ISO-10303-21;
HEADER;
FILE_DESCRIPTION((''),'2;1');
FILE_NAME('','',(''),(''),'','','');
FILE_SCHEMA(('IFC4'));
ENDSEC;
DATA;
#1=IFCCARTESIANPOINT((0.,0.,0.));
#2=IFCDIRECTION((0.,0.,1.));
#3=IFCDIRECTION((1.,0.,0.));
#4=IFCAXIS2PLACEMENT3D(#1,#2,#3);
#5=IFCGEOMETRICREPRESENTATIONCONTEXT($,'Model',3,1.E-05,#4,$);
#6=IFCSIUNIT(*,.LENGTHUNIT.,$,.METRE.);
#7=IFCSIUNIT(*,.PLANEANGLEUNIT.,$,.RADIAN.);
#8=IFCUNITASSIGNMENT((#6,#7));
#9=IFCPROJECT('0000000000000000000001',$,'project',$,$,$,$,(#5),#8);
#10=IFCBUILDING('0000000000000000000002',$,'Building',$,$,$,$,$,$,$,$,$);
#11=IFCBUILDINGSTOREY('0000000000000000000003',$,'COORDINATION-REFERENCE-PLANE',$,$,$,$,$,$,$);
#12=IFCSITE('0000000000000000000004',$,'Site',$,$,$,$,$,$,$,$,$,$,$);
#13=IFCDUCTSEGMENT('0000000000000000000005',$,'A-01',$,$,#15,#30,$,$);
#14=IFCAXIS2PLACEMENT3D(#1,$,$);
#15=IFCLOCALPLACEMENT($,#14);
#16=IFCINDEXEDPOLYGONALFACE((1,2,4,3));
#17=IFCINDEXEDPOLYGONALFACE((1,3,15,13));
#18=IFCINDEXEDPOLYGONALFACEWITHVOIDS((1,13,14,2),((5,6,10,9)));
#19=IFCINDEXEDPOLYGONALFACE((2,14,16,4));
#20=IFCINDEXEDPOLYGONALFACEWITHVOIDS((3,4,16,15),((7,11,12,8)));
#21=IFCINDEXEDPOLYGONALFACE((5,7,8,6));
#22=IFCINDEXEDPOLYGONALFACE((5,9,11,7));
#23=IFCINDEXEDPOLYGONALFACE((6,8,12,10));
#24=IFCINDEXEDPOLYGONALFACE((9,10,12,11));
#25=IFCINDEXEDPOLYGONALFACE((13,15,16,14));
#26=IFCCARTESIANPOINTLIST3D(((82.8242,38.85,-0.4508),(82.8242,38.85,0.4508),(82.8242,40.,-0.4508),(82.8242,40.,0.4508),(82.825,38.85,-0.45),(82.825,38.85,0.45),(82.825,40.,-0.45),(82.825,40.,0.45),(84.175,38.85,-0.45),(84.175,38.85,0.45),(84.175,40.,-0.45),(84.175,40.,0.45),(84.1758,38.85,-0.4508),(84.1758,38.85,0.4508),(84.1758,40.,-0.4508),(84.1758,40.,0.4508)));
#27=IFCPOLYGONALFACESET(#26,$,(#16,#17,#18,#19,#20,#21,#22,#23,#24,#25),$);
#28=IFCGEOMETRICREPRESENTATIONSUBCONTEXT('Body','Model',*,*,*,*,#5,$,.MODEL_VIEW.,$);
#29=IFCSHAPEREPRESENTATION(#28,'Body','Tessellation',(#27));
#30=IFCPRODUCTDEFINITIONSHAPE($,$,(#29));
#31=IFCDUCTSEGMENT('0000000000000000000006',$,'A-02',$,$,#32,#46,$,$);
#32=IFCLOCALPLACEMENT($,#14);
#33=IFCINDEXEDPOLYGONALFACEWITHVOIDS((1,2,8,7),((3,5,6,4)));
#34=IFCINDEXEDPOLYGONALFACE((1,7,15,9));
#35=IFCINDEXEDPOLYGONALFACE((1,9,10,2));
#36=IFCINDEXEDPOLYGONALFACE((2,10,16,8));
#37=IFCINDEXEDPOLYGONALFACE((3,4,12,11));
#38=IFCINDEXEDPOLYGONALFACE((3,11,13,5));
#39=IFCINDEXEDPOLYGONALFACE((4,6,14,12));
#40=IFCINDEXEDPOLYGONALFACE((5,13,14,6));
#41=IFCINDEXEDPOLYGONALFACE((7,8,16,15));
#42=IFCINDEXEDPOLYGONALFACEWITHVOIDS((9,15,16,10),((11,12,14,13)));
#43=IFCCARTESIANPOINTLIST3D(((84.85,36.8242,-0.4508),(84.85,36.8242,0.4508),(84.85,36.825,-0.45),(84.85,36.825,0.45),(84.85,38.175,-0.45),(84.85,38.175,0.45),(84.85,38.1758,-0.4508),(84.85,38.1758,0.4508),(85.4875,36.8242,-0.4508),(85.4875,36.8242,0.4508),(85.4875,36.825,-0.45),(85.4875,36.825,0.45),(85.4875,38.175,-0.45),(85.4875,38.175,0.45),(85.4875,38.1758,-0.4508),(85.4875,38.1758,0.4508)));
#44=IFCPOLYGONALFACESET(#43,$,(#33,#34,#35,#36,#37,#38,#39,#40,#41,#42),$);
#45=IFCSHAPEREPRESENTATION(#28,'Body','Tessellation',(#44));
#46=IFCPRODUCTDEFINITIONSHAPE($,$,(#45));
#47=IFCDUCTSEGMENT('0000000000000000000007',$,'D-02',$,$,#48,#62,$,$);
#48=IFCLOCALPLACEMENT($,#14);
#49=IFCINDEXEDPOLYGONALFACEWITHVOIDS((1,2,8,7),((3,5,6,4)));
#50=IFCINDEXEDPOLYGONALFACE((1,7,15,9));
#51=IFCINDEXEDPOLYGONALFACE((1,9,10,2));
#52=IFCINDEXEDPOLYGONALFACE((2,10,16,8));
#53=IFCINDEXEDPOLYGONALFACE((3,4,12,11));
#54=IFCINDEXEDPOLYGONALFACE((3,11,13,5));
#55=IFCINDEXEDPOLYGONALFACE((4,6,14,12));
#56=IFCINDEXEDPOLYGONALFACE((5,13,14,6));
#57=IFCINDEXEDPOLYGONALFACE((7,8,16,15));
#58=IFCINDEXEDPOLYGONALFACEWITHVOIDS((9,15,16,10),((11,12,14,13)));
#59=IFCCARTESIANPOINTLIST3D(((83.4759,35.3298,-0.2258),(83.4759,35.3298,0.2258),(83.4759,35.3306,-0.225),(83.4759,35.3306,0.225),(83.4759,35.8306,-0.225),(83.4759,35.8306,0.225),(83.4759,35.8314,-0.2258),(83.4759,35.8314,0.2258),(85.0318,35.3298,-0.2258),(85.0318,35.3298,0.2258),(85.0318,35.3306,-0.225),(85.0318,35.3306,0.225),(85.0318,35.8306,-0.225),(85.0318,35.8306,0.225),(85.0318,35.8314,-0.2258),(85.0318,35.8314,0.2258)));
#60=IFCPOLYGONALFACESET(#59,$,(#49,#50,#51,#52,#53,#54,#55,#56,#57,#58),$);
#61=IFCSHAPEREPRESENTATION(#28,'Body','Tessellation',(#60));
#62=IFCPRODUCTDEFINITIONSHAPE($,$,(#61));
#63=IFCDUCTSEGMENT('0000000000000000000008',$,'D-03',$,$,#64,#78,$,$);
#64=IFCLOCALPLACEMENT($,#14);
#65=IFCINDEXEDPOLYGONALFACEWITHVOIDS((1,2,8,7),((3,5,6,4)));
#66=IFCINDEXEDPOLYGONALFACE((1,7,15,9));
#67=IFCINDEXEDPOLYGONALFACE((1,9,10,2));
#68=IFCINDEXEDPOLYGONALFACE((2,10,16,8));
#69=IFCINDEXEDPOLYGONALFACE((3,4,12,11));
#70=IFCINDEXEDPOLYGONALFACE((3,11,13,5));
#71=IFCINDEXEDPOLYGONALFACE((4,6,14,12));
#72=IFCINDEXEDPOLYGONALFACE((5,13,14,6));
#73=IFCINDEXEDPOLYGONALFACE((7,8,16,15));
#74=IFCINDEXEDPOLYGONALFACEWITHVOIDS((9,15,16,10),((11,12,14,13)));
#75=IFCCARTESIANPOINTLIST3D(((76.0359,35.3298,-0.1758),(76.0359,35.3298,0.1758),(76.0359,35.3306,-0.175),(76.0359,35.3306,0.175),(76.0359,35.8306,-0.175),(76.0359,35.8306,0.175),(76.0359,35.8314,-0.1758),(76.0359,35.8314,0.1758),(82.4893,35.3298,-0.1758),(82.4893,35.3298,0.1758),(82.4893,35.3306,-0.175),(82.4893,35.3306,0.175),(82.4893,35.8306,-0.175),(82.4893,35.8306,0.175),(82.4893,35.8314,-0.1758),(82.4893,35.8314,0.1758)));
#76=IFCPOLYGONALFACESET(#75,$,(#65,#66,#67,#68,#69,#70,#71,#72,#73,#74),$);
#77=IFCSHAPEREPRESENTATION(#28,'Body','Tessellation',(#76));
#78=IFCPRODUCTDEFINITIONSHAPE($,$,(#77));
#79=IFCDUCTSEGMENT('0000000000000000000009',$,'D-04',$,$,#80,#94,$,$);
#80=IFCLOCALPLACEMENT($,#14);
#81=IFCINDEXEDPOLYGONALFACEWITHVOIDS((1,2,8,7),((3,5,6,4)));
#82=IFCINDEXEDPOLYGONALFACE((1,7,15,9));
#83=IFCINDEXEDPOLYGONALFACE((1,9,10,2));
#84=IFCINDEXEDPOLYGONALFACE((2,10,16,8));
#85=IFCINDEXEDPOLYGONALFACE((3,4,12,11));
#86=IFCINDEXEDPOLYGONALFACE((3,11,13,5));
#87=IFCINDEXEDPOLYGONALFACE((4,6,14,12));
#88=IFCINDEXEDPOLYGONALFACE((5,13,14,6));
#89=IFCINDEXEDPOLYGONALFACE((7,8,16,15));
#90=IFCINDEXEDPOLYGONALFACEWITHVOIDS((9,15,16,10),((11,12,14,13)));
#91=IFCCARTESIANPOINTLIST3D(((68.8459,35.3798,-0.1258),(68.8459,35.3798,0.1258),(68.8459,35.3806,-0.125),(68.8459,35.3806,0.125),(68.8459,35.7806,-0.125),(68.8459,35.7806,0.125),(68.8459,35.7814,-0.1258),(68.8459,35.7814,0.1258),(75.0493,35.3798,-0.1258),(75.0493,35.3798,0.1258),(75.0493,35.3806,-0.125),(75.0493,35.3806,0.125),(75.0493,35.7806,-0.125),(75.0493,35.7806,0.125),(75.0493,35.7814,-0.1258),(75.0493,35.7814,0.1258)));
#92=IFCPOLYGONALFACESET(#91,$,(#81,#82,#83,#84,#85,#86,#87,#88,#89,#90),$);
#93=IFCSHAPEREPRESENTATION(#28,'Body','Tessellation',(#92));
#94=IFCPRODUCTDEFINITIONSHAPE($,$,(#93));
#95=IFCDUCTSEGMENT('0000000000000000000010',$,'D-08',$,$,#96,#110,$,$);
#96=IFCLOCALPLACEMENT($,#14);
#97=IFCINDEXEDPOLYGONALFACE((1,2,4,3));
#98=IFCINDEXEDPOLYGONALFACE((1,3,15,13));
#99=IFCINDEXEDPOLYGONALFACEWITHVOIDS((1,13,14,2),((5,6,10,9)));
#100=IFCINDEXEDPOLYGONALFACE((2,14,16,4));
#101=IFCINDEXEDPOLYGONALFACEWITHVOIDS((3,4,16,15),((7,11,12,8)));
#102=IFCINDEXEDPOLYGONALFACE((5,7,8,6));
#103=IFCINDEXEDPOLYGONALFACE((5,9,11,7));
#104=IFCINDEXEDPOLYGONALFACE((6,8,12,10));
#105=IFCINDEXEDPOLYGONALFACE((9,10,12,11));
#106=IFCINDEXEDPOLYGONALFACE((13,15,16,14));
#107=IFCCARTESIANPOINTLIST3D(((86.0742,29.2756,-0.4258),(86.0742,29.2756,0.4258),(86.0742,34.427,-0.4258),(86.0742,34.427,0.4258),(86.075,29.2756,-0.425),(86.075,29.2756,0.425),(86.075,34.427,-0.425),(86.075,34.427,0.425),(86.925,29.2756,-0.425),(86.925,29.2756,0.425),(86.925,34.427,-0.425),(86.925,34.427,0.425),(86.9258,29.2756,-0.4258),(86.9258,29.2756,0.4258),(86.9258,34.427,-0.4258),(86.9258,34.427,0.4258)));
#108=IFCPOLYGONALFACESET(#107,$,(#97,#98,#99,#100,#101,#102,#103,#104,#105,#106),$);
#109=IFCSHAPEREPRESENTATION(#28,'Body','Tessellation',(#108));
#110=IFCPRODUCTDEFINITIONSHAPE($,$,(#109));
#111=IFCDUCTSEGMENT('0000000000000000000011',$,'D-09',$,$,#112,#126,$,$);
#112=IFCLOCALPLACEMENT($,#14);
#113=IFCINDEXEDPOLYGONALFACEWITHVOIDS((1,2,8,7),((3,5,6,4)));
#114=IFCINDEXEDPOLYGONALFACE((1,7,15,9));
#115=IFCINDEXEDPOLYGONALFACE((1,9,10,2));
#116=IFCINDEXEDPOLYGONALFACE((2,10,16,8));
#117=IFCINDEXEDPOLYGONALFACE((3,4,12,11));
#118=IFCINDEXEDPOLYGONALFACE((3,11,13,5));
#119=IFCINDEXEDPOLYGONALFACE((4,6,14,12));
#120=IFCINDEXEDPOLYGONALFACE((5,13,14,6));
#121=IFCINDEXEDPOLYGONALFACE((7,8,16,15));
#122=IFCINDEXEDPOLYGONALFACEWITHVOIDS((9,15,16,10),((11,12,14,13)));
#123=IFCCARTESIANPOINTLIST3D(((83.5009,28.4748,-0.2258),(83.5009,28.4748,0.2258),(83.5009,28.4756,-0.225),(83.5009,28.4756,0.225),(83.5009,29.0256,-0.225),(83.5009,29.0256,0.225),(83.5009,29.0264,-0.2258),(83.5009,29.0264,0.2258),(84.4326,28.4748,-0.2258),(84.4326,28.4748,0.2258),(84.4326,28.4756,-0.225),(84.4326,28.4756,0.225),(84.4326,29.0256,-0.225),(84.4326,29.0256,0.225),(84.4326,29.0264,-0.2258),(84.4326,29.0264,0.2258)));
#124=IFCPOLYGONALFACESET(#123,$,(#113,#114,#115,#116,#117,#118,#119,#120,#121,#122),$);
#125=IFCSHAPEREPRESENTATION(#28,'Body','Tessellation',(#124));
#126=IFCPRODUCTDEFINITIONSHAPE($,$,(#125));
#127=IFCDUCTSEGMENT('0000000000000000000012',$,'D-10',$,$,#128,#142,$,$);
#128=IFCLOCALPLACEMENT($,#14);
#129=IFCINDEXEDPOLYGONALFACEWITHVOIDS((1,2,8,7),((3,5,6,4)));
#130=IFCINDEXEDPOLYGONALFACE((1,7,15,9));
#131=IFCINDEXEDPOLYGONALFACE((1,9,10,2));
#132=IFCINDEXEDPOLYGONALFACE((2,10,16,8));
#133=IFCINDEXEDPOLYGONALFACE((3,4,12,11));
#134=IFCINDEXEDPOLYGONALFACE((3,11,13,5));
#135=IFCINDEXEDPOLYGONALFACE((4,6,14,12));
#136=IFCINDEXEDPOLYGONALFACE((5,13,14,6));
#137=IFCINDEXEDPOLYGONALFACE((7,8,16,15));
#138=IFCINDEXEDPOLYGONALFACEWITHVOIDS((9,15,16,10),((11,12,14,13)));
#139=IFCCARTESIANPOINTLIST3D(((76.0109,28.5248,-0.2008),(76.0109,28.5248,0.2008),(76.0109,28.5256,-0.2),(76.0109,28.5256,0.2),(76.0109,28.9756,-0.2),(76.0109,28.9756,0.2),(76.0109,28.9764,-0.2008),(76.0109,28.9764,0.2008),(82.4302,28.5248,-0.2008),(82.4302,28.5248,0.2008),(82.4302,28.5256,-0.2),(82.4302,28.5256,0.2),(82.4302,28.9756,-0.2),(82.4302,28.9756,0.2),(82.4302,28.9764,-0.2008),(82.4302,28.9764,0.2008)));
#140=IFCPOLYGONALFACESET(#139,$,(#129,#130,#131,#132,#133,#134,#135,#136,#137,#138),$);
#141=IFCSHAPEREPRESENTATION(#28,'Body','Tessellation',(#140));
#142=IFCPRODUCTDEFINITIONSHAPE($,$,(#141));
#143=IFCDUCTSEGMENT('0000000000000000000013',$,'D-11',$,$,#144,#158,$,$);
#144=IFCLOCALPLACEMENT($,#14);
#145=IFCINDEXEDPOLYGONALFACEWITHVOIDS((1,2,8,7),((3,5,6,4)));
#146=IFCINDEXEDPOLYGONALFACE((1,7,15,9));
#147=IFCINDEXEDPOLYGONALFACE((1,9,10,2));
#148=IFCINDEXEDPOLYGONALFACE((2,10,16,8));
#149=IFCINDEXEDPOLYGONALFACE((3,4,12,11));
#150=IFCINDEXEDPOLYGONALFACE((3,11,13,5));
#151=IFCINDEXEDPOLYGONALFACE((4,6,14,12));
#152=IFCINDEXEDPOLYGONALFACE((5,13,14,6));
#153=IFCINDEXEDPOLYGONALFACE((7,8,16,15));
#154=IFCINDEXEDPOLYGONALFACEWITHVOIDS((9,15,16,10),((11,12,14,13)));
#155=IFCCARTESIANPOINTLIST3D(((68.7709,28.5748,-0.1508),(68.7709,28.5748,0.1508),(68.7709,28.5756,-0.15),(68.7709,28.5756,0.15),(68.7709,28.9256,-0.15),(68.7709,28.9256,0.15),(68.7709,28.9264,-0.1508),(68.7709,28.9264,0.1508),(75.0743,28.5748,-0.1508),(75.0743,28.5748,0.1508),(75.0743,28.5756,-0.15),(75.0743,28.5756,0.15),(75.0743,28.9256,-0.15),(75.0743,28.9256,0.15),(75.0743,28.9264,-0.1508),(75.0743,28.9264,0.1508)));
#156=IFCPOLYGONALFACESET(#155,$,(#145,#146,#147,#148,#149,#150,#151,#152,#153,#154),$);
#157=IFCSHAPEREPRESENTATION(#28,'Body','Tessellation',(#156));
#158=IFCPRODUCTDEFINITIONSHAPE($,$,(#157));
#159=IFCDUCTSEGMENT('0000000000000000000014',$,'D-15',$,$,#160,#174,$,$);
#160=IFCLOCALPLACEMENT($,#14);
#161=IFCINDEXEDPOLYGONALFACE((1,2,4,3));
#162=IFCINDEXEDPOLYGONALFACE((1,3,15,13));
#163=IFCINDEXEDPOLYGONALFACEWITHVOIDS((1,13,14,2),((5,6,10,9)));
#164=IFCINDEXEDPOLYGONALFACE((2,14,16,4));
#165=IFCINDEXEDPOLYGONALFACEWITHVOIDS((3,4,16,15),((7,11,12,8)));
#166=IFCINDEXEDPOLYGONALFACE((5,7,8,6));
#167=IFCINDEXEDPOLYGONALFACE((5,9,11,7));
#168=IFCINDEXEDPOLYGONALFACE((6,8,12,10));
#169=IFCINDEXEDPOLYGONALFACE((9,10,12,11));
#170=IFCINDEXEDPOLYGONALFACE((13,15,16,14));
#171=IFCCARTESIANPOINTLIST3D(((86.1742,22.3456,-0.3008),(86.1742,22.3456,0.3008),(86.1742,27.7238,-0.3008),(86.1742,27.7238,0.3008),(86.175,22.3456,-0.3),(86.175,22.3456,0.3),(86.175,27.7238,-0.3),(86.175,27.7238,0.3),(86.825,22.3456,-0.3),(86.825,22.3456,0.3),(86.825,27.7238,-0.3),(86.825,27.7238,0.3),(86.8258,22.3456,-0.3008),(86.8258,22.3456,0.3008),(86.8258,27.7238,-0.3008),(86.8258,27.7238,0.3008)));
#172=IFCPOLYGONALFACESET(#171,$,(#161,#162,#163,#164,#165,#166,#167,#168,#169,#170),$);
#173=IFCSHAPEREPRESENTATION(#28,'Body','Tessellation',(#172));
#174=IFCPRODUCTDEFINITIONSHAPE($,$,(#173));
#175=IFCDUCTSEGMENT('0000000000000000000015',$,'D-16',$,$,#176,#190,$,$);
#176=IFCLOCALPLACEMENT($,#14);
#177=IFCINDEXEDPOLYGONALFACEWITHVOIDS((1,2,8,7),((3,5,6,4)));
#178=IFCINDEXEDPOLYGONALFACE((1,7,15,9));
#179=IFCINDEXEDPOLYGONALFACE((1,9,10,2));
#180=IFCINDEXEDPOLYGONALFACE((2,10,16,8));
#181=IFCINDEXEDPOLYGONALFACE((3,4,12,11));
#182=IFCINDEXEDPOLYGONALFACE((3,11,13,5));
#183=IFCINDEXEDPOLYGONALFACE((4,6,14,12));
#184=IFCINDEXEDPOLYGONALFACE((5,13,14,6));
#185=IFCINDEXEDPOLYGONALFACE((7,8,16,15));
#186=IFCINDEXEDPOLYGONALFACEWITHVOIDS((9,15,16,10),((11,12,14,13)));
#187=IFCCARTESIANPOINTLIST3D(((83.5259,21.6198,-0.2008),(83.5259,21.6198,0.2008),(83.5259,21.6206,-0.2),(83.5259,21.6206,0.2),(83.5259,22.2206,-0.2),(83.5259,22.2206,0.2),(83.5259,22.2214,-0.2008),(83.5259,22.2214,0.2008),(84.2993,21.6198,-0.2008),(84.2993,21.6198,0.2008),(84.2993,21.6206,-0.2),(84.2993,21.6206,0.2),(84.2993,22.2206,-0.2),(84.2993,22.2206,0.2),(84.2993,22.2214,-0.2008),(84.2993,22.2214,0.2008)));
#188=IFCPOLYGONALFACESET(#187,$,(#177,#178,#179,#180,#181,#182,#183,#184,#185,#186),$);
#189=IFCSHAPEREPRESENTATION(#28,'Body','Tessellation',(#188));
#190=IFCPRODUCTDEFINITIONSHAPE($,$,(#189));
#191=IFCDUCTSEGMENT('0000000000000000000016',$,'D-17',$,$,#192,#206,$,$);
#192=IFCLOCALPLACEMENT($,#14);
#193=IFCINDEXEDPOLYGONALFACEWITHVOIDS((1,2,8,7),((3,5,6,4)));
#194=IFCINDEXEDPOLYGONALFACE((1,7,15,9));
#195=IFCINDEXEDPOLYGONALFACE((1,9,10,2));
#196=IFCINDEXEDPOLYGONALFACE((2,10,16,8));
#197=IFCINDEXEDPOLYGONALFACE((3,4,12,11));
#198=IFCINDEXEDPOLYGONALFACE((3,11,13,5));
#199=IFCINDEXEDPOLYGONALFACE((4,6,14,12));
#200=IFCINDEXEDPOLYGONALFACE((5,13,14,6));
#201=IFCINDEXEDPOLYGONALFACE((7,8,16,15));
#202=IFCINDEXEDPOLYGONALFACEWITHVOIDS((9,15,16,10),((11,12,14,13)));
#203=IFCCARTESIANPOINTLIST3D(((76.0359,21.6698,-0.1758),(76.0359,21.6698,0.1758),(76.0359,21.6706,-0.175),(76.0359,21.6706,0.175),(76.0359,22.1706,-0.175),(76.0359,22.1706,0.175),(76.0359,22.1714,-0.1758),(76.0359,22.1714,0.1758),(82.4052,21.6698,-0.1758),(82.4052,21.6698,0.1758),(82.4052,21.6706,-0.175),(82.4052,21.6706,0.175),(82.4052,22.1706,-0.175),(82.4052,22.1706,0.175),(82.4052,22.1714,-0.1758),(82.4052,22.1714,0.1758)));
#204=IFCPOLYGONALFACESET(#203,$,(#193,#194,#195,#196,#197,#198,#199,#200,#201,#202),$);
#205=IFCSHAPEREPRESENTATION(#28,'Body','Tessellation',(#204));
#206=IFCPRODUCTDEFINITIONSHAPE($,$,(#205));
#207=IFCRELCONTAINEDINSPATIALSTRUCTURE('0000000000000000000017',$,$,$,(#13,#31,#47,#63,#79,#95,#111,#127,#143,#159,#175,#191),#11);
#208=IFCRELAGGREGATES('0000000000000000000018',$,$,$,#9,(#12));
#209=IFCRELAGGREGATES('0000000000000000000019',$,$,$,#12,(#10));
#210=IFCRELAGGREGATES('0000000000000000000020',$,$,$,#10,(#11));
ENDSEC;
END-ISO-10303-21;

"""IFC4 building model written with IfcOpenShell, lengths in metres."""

from ifc_helpers import new_model, si_unit, frame, origin, origin_with_axes, place, context, subcontext, project, spatial, hollow_rectangle, extrude, element, save


model = new_model("IFC4")

# Units and contexts
model_context = context("Model", 3, precision=1e-05, world=origin_with_axes())
body_context = subcontext(model_context, "Body", "Model", "MODEL_VIEW")
ifc_project = project(units=[si_unit("LENGTHUNIT", "METRE"), si_unit("PLANEANGLEUNIT", "RADIAN")], contexts=[model_context])

# Site, building, storey
site = spatial("IfcSite", under=ifc_project, Name="Site")
building = spatial("IfcBuilding", under=site, Name="Building")
storey = spatial("IfcBuildingStorey", under=building, Name="COORDINATION-REFERENCE-PLANE")

# Duct segments
duct_segment_1_placement = place(None, frame((83.5, 38.85, 0.0), z_axis=(0.0, 1.0, 0.0), x_axis=(1.0, 0.0, 0.0)))
element("IfcDuctSegment", 1, at=duct_segment_1_placement, inside=storey, Name="A-01", context=body_context, shape_type="SweptSolid", body=[
    extrude(hollow_rectangle(XDim=1.3516, YDim=0.9016, WallThickness=0.0008), origin(), (0.0, 0.0, 1.0), 1.15),
])
duct_segment_2_placement = place(None, frame((84.85, 37.5, 0.0), z_axis=(1.0, 0.0, 0.0), x_axis=(0.0, 1.0, 0.0)))
element("IfcDuctSegment", 2, at=duct_segment_2_placement, inside=storey, Name="A-02", context=body_context, shape_type="SweptSolid", body=[
    extrude(hollow_rectangle(XDim=1.3516, YDim=0.9016, WallThickness=0.0008), origin(), (0.0, 0.0, 1.0), 0.6375),
])
duct_segment_3_placement = place(None, frame((83.4759, 35.5806, 0.0), z_axis=(1.0, 0.0, 0.0), x_axis=(0.0, 1.0, 0.0)))
element("IfcDuctSegment", 3, at=duct_segment_3_placement, inside=storey, Name="D-02", context=body_context, shape_type="SweptSolid", body=[
    extrude(hollow_rectangle(XDim=0.5016, YDim=0.4516, WallThickness=0.0008), origin(), (0.0, 0.0, 1.0), 1.5559),
])
duct_segment_4_placement = place(None, frame((76.0359, 35.5806, 0.0), z_axis=(1.0, 0.0, 0.0), x_axis=(0.0, 1.0, 0.0)))
element("IfcDuctSegment", 4, at=duct_segment_4_placement, inside=storey, Name="D-03", context=body_context, shape_type="SweptSolid", body=[
    extrude(hollow_rectangle(XDim=0.5016, YDim=0.3516, WallThickness=0.0008), origin(), (0.0, 0.0, 1.0), 6.4534),
])
duct_segment_5_placement = place(None, frame((68.8459, 35.5806, 0.0), z_axis=(1.0, 0.0, 0.0), x_axis=(0.0, 1.0, 0.0)))
element("IfcDuctSegment", 5, at=duct_segment_5_placement, inside=storey, Name="D-04", context=body_context, shape_type="SweptSolid", body=[
    extrude(hollow_rectangle(XDim=0.4016, YDim=0.2516, WallThickness=0.0008), origin(), (0.0, 0.0, 1.0), 6.2034),
])
duct_segment_6_placement = place(None, frame((86.5, 29.2756, 0.0), z_axis=(0.0, 1.0, 0.0), x_axis=(1.0, 0.0, 0.0)))
element("IfcDuctSegment", 6, at=duct_segment_6_placement, inside=storey, Name="D-08", context=body_context, shape_type="SweptSolid", body=[
    extrude(hollow_rectangle(XDim=0.8516, YDim=0.8516, WallThickness=0.0008), origin(), (0.0, 0.0, 1.0), 5.1514),
])
duct_segment_7_placement = place(None, frame((83.5009, 28.7506, 0.0), z_axis=(1.0, 0.0, 0.0), x_axis=(0.0, 1.0, 0.0)))
element("IfcDuctSegment", 7, at=duct_segment_7_placement, inside=storey, Name="D-09", context=body_context, shape_type="SweptSolid", body=[
    extrude(hollow_rectangle(XDim=0.5516, YDim=0.4516, WallThickness=0.0008), origin(), (0.0, 0.0, 1.0), 0.9316),
])
duct_segment_8_placement = place(None, frame((76.0109, 28.7506, 0.0), z_axis=(1.0, 0.0, 0.0), x_axis=(0.0, 1.0, 0.0)))
element("IfcDuctSegment", 8, at=duct_segment_8_placement, inside=storey, Name="D-10", context=body_context, shape_type="SweptSolid", body=[
    extrude(hollow_rectangle(XDim=0.4516, YDim=0.4016, WallThickness=0.0008), origin(), (0.0, 0.0, 1.0), 6.4193),
])
duct_segment_9_placement = place(None, frame((68.7709, 28.7506, 0.0), z_axis=(1.0, 0.0, 0.0), x_axis=(0.0, 1.0, 0.0)))
element("IfcDuctSegment", 9, at=duct_segment_9_placement, inside=storey, Name="D-11", context=body_context, shape_type="SweptSolid", body=[
    extrude(hollow_rectangle(XDim=0.3516, YDim=0.3016, WallThickness=0.0008), origin(), (0.0, 0.0, 1.0), 6.3034),
])
duct_segment_10_placement = place(None, frame((86.5, 22.3456, 0.0), z_axis=(0.0, 1.0, 0.0), x_axis=(1.0, 0.0, 0.0)))
element("IfcDuctSegment", 10, at=duct_segment_10_placement, inside=storey, Name="D-15", context=body_context, shape_type="SweptSolid", body=[
    extrude(hollow_rectangle(XDim=0.6516, YDim=0.6016, WallThickness=0.0008), origin(), (0.0, 0.0, 1.0), 5.3782),
])
duct_segment_11_placement = place(None, frame((83.5259, 21.9206, 0.0), z_axis=(1.0, 0.0, 0.0), x_axis=(0.0, 1.0, 0.0)))
element("IfcDuctSegment", 11, at=duct_segment_11_placement, inside=storey, Name="D-16", context=body_context, shape_type="SweptSolid", body=[
    extrude(hollow_rectangle(XDim=0.6016, YDim=0.4016, WallThickness=0.0008), origin(), (0.0, 0.0, 1.0), 0.7733),
])
duct_segment_12_placement = place(None, frame((76.0359, 21.9206, 0.0), z_axis=(1.0, 0.0, 0.0), x_axis=(0.0, 1.0, 0.0)))
element("IfcDuctSegment", 12, at=duct_segment_12_placement, inside=storey, Name="D-17", context=body_context, shape_type="SweptSolid", body=[
    extrude(hollow_rectangle(XDim=0.5016, YDim=0.3516, WallThickness=0.0008), origin(), (0.0, 0.0, 1.0), 6.3693),
])

save(model, "model.ifc")
